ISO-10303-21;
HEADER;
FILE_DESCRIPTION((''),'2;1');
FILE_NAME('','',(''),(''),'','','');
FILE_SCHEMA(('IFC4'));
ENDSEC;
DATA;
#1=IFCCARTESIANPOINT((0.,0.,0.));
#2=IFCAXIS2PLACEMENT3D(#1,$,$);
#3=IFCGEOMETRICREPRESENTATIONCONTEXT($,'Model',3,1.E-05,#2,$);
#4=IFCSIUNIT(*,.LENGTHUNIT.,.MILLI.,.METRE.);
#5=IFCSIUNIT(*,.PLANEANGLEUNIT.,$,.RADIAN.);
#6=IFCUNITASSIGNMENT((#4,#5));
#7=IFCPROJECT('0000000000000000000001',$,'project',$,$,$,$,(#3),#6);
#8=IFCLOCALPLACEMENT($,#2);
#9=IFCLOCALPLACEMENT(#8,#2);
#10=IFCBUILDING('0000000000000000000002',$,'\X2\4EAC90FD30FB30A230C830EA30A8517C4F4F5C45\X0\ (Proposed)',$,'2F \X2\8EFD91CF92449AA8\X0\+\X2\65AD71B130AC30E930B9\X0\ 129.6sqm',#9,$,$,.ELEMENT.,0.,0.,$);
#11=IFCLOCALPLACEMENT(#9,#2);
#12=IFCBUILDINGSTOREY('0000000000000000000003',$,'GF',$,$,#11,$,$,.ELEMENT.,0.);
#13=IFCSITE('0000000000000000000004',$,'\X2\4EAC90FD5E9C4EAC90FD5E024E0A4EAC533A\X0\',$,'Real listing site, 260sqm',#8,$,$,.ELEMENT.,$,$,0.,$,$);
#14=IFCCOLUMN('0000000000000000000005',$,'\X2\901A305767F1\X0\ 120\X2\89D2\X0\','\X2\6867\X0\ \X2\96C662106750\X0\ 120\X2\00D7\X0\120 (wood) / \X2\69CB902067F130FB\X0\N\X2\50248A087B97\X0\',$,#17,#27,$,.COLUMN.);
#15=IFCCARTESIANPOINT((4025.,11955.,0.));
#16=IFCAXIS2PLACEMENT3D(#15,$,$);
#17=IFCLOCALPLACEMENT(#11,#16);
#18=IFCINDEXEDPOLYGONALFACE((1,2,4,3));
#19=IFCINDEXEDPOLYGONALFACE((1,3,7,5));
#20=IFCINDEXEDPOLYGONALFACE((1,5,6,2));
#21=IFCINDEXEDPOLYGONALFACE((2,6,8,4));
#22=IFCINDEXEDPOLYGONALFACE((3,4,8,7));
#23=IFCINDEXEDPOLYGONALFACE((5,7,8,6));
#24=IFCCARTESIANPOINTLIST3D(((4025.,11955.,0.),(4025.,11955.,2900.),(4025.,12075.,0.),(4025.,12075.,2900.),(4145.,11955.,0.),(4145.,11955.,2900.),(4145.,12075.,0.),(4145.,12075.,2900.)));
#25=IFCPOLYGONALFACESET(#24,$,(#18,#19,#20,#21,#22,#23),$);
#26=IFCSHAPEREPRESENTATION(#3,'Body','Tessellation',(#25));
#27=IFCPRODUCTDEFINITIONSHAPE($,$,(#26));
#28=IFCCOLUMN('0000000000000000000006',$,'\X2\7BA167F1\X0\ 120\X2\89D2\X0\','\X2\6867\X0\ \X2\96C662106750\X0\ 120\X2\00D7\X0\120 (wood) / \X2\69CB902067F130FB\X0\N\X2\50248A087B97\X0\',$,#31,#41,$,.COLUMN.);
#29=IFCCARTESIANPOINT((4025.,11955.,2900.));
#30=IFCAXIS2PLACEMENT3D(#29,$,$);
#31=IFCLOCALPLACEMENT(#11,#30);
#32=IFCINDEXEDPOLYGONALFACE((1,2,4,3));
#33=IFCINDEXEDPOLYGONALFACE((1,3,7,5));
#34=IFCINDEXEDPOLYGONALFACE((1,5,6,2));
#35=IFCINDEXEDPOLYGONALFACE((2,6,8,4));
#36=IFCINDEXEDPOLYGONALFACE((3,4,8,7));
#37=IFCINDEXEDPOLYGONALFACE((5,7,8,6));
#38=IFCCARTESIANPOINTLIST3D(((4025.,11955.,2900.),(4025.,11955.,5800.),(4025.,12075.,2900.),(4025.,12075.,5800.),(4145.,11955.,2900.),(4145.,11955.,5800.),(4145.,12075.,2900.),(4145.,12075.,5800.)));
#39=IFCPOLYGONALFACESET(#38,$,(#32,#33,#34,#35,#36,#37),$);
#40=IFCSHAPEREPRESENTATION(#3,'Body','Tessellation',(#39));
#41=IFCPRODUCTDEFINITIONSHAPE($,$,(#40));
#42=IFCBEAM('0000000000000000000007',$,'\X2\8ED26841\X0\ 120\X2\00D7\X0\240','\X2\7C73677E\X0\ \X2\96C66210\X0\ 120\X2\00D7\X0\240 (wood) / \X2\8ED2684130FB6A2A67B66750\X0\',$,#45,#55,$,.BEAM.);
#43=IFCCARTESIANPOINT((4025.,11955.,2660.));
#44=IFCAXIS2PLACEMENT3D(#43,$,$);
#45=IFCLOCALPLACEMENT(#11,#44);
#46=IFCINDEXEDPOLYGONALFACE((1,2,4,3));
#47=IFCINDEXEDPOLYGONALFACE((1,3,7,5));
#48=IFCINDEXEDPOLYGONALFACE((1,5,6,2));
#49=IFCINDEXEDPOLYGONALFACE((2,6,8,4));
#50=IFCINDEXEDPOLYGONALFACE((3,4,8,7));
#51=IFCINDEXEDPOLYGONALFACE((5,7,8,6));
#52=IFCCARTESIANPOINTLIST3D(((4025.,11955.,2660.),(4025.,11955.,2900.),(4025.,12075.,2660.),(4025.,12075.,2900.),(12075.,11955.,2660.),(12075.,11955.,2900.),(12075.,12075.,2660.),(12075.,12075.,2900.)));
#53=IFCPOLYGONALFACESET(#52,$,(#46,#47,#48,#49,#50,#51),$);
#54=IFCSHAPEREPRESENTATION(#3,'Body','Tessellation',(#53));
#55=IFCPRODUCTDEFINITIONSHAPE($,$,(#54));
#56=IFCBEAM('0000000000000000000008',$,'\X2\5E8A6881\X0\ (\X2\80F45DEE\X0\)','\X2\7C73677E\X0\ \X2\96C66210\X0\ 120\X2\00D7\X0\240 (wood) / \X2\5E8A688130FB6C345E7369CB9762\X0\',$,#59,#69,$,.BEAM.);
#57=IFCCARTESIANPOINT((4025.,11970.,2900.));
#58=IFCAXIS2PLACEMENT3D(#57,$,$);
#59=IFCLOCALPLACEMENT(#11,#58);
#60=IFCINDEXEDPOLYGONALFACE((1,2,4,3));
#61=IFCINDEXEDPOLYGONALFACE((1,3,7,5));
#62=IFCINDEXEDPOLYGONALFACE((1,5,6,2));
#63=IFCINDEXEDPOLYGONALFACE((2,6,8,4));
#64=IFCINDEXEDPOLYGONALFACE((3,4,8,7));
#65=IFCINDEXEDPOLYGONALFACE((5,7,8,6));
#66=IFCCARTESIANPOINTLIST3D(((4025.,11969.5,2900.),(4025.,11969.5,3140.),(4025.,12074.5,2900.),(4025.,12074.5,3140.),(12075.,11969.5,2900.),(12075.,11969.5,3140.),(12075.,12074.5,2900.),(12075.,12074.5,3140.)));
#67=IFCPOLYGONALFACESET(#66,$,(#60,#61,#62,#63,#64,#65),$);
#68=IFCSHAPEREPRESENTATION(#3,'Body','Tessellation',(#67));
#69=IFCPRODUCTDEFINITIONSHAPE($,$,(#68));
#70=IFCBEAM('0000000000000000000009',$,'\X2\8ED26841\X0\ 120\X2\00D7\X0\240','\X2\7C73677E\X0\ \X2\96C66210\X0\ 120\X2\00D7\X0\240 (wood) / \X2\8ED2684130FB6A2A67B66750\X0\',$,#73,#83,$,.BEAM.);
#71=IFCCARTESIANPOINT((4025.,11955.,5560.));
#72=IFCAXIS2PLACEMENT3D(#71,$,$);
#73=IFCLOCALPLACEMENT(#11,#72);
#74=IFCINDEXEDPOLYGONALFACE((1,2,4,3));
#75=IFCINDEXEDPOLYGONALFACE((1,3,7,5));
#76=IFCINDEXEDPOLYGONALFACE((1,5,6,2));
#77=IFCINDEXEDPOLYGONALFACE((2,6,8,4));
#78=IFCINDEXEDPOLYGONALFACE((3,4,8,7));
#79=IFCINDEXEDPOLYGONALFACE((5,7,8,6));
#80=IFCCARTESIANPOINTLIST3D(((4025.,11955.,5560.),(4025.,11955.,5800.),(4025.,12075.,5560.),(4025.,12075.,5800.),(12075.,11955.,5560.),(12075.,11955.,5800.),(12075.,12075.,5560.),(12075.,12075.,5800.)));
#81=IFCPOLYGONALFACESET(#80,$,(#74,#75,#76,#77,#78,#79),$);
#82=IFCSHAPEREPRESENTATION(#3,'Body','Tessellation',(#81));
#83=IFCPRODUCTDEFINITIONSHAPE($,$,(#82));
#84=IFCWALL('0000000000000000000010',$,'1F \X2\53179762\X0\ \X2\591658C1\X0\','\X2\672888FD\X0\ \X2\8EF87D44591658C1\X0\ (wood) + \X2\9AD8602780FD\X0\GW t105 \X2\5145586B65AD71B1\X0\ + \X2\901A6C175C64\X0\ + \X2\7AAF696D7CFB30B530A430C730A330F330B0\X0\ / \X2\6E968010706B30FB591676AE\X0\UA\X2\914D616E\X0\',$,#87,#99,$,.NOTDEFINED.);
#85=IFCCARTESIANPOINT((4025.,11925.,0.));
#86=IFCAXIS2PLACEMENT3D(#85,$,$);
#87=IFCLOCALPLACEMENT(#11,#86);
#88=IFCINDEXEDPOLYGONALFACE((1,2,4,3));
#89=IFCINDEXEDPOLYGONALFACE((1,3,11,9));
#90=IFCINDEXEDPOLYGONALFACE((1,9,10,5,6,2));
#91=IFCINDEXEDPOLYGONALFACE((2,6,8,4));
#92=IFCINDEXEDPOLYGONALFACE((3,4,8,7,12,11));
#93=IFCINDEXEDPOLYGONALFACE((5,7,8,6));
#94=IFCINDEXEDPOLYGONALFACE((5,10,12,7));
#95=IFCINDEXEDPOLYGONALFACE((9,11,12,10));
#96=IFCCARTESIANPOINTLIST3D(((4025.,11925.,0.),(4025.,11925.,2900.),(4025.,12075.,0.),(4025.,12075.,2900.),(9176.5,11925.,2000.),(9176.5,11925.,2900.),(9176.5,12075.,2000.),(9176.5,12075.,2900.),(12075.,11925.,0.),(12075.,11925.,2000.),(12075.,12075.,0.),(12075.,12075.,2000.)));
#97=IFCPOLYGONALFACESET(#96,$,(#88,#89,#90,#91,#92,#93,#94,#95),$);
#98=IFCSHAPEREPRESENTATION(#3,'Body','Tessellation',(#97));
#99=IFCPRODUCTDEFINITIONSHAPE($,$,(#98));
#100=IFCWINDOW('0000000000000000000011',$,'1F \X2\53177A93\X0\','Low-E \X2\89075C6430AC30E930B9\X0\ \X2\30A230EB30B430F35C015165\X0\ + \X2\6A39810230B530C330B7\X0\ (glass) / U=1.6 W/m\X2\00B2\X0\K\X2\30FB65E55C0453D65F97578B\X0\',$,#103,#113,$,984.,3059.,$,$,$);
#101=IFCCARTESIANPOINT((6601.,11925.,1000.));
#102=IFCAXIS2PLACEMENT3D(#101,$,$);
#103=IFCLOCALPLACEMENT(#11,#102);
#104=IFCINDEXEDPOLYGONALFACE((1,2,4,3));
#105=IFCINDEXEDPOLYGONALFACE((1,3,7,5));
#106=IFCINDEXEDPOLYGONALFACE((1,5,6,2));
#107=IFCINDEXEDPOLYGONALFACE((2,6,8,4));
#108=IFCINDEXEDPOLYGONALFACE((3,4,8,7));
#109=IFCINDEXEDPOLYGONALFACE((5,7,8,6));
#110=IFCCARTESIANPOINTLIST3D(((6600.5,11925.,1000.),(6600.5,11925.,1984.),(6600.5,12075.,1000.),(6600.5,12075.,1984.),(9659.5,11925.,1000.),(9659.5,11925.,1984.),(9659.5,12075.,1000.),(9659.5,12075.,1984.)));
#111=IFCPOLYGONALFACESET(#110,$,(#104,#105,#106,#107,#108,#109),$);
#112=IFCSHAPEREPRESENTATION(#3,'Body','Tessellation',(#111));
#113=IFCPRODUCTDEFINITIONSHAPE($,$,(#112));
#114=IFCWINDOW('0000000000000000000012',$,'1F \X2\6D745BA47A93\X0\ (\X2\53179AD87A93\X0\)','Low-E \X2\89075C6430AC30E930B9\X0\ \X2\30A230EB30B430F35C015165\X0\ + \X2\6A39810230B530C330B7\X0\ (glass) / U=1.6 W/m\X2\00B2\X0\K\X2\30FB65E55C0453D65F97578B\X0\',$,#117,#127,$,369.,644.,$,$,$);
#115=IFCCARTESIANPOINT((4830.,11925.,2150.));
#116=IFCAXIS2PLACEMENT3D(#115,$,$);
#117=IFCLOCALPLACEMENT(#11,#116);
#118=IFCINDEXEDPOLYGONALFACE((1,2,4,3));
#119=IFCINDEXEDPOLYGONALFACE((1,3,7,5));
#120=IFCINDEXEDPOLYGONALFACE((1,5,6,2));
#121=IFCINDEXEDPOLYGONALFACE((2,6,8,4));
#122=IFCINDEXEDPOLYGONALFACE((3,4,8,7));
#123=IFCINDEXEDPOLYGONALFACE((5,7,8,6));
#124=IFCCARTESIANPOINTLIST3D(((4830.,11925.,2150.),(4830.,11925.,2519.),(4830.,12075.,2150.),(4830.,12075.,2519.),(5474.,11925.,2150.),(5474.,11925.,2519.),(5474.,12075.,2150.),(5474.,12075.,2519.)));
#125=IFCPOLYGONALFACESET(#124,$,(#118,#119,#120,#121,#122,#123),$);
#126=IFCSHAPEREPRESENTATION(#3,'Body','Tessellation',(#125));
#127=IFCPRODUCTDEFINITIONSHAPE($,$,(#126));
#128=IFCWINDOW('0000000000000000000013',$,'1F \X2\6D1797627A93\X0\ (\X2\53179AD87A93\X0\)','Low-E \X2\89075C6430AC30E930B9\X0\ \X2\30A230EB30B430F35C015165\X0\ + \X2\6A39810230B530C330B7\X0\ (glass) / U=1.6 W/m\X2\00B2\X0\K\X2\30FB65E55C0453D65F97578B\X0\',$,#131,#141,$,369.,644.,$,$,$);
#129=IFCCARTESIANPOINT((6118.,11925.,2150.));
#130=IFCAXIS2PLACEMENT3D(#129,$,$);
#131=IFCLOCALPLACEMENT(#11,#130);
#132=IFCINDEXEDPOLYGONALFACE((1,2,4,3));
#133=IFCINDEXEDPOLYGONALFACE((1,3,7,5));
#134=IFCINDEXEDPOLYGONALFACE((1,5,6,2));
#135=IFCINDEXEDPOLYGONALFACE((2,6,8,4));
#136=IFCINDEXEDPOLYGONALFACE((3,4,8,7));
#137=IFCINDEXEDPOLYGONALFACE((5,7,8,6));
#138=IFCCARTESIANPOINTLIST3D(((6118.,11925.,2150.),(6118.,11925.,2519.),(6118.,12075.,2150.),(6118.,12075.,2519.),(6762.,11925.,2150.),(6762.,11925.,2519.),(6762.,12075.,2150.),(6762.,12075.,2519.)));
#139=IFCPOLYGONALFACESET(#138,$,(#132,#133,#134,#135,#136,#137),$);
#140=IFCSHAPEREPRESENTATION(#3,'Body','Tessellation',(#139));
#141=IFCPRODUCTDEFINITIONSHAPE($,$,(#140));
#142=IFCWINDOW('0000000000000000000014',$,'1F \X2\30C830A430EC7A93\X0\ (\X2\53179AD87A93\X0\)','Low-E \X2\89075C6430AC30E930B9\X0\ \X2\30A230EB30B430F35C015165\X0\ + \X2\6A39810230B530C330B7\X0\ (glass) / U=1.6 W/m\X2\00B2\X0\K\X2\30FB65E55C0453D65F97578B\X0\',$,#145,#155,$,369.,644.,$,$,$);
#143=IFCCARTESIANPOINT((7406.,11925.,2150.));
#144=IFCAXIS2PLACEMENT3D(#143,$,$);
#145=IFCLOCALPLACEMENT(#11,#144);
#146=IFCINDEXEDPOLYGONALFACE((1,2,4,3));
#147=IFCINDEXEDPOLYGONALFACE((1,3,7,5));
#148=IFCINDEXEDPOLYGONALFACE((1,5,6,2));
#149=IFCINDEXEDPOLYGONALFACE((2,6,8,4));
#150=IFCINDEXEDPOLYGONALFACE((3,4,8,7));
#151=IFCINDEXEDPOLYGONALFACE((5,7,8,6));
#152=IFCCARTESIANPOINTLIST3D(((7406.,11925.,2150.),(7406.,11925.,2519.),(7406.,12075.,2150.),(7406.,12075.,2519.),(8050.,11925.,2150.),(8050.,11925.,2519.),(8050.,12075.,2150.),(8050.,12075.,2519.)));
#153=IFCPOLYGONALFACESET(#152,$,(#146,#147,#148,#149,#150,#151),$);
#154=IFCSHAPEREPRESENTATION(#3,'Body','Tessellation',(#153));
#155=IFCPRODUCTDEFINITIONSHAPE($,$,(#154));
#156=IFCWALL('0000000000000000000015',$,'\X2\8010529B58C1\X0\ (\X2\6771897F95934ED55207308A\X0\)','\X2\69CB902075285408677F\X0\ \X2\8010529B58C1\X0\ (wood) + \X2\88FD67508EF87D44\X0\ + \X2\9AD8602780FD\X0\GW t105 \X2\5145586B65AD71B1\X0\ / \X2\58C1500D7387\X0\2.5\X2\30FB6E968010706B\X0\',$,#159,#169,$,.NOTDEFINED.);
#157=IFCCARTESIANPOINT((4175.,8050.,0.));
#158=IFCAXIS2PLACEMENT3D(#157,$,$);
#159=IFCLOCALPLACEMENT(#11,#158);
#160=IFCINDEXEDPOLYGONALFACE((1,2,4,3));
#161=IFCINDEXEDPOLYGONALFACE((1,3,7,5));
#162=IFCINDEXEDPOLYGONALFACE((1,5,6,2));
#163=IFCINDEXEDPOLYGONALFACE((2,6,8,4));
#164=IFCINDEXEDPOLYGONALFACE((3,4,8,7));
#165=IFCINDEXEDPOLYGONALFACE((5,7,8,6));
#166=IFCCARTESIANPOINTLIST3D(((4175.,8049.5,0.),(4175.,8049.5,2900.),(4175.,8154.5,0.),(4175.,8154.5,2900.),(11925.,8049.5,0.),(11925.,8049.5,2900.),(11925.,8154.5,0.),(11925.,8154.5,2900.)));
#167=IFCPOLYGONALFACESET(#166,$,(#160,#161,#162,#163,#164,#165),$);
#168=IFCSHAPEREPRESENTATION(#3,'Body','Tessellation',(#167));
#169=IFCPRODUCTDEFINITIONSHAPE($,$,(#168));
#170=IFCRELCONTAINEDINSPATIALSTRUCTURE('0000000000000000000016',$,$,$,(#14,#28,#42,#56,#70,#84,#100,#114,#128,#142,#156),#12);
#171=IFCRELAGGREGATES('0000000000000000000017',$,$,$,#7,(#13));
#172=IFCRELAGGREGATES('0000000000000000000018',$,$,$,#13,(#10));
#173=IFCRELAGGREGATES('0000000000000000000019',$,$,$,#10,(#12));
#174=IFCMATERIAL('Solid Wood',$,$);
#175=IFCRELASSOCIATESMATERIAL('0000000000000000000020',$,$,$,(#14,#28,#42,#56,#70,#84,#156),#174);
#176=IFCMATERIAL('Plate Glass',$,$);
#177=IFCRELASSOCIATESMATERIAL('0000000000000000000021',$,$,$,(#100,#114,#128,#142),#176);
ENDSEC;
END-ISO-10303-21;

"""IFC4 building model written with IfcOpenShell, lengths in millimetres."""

from ifc_helpers import new_model, si_unit, frame, frame_2d, origin, place, context, project, spatial, rectangle, extrude, material, element, fill, save


model = new_model("IFC4")

# Units and contexts
model_context = context("Model", 3, precision=1e-05, world=origin())
ifc_project = project(units=[si_unit("LENGTHUNIT", "METRE", prefix="MILLI"), si_unit("PLANEANGLEUNIT", "RADIAN")], contexts=[model_context])

# Site, building, storey
site_placement = place(None, origin())
site = spatial("IfcSite", under=ifc_project, at=site_placement, Name="京都府京都市上京区", ObjectType="Real listing site, 260sqm", CompositionType="ELEMENT", RefElevation=0.0)
building_placement = place(site_placement, origin())
building = spatial("IfcBuilding", under=site, at=building_placement, Name="京都・アトリエ兼住居 (Proposed)", ObjectType="2F 軽量鉄骨+断熱ガラス 129.6sqm", CompositionType="ELEMENT", ElevationOfRefHeight=0.0, ElevationOfTerrain=0.0)
storey_placement = place(building_placement, origin())
storey = spatial("IfcBuildingStorey", under=building, at=storey_placement, Name="GF", CompositionType="ELEMENT", Elevation=0.0)

# Columns
ifc_material_1 = material(Name="Solid Wood")
column_1_placement = place(storey_placement, frame((4025.0, 11955.0, 0.0)))
element("IfcColumn", 1, at=column_1_placement, inside=storey, material=ifc_material_1, Name="通し柱 120角", Description="桧 集成材 120×120 (wood) / 構造柱・N値計算", PredefinedType="COLUMN", context=model_context, shape_type="SweptSolid", body=[
    extrude(rectangle(XDim=120.0, YDim=120.0, at=frame_2d((60.0, 60.0))), frame((4025.0, 11955.0, 0.0)), (0.0, 0.0, 1.0), 2900.0),
])
column_2_placement = place(storey_placement, frame((4025.0, 11955.0, 2900.0)))
element("IfcColumn", 2, at=column_2_placement, inside=storey, material=ifc_material_1, Name="管柱 120角", Description="桧 集成材 120×120 (wood) / 構造柱・N値計算", PredefinedType="COLUMN", context=model_context, shape_type="SweptSolid", body=[
    extrude(rectangle(XDim=120.0, YDim=120.0, at=frame_2d((60.0, 60.0))), frame((4025.0, 11955.0, 2900.0)), (0.0, 0.0, 1.0), 2900.0),
])

# Beams
beam_1_placement = place(storey_placement, frame((4025.0, 11955.0, 2660.0)))
element("IfcBeam", 3, at=beam_1_placement, inside=storey, material=ifc_material_1, Name="軒桁 120×240", Description="米松 集成 120×240 (wood) / 軒桁・横架材", PredefinedType="BEAM", context=model_context, shape_type="SweptSolid", body=[
    extrude(rectangle(XDim=8050.0, YDim=120.0, at=frame_2d((4025.0, 60.0))), frame((4025.0, 11955.0, 2660.0)), (0.0, 0.0, 1.0), 240.0),
])
beam_2_placement = place(storey_placement, frame((4025.0, 11970.0, 2900.0)))
element("IfcBeam", 4, at=beam_2_placement, inside=storey, material=ifc_material_1, Name="床梁 (胴差)", Description="米松 集成 120×240 (wood) / 床梁・水平構面", PredefinedType="BEAM", context=model_context, shape_type="SweptSolid", body=[
    extrude(rectangle(XDim=8050.0, YDim=105.0, at=frame_2d((4025.0, 52.0))), frame((4025.0, 11970.0, 2900.0)), (0.0, 0.0, 1.0), 240.0),
])
beam_3_placement = place(storey_placement, frame((4025.0, 11955.0, 5560.0)))
element("IfcBeam", 5, at=beam_3_placement, inside=storey, material=ifc_material_1, Name="軒桁 120×240", Description="米松 集成 120×240 (wood) / 軒桁・横架材", PredefinedType="BEAM", context=model_context, shape_type="SweptSolid", body=[
    extrude(rectangle(XDim=8050.0, YDim=120.0, at=frame_2d((4025.0, 60.0))), frame((4025.0, 11955.0, 5560.0)), (0.0, 0.0, 1.0), 240.0),
])

# Wall, openings, windows
wall_1_placement = place(storey_placement, frame((4025.0, 11925.0, 0.0)))
wall_1 = element("IfcWall", 6, at=wall_1_placement, inside=storey, material=ifc_material_1, Name="1F 北面 外壁", Description="木製 軸組外壁 (wood) + 高性能GW t105 充填断熱 + 通気層 + 窯業系サイディング / 準耐火・外皮UA配慮", PredefinedType="NOTDEFINED", context=model_context, shape_type="SweptSolid", body=[
    extrude(rectangle(XDim=8050.0, YDim=150.0, at=frame_2d((4025.0, 75.0))), frame((4025.0, 11925.0, 0.0)), (0.0, 0.0, 1.0), 2900.0),
])
opening_1_placement = place(storey_placement, frame((6601.0, 11925.0, 1000.0)))
opening_1 = element("IfcOpeningElement", 7, at=opening_1_placement, cuts=wall_1, PredefinedType="NOTDEFINED", context=model_context, shape_type="SweptSolid", body=[
    extrude(rectangle(XDim=3059.0, YDim=150.0, at=frame_2d((1529.0, 75.0))), frame((6601.0, 11925.0, 1000.0)), (0.0, 0.0, 1.0), 984.0),
])
opening_2_placement = place(storey_placement, frame((4830.0, 11925.0, 2150.0)))
opening_2 = element("IfcOpeningElement", 8, at=opening_2_placement, cuts=wall_1, PredefinedType="NOTDEFINED", context=model_context, shape_type="SweptSolid", body=[
    extrude(rectangle(XDim=644.0, YDim=150.0, at=frame_2d((322.0, 75.0))), frame((4830.0, 11925.0, 2150.0)), (0.0, 0.0, 1.0), 369.0),
])
opening_3_placement = place(storey_placement, frame((6118.0, 11925.0, 2150.0)))
opening_3 = element("IfcOpeningElement", 9, at=opening_3_placement, cuts=wall_1, PredefinedType="NOTDEFINED", context=model_context, shape_type="SweptSolid", body=[
    extrude(rectangle(XDim=644.0, YDim=150.0, at=frame_2d((322.0, 75.0))), frame((6118.0, 11925.0, 2150.0)), (0.0, 0.0, 1.0), 369.0),
])
opening_4_placement = place(storey_placement, frame((7406.0, 11925.0, 2150.0)))
opening_4 = element("IfcOpeningElement", 10, at=opening_4_placement, cuts=wall_1, PredefinedType="NOTDEFINED", context=model_context, shape_type="SweptSolid", body=[
    extrude(rectangle(XDim=644.0, YDim=150.0, at=frame_2d((322.0, 75.0))), frame((7406.0, 11925.0, 2150.0)), (0.0, 0.0, 1.0), 369.0),
])
ifc_material_2 = material(Name="Plate Glass")
window_1_placement = place(storey_placement, frame((6601.0, 11925.0, 1000.0)))
window_1 = element("IfcWindow", 11, at=window_1_placement, inside=storey, material=ifc_material_2, Name="1F 北窓", Description="Low-E 複層ガラス アルゴン封入 + 樹脂サッシ (glass) / U=1.6 W/m²K・日射取得型", OverallHeight=984.0, OverallWidth=3059.0, context=model_context, shape_type="SweptSolid", body=[
    extrude(rectangle(XDim=3059.0, YDim=150.0, at=frame_2d((1529.0, 75.0))), frame((6601.0, 11925.0, 1000.0)), (0.0, 0.0, 1.0), 984.0),
])
fill(opening_1, window_1)
window_2_placement = place(storey_placement, frame((4830.0, 11925.0, 2150.0)))
window_2 = element("IfcWindow", 12, at=window_2_placement, inside=storey, material=ifc_material_2, Name="1F 浴室窓 (北高窓)", Description="Low-E 複層ガラス アルゴン封入 + 樹脂サッシ (glass) / U=1.6 W/m²K・日射取得型", OverallHeight=369.0, OverallWidth=644.0, context=model_context, shape_type="SweptSolid", body=[
    extrude(rectangle(XDim=644.0, YDim=150.0, at=frame_2d((322.0, 75.0))), frame((4830.0, 11925.0, 2150.0)), (0.0, 0.0, 1.0), 369.0),
])
fill(opening_2, window_2)
window_3_placement = place(storey_placement, frame((6118.0, 11925.0, 2150.0)))
window_3 = element("IfcWindow", 13, at=window_3_placement, inside=storey, material=ifc_material_2, Name="1F 洗面窓 (北高窓)", Description="Low-E 複層ガラス アルゴン封入 + 樹脂サッシ (glass) / U=1.6 W/m²K・日射取得型", OverallHeight=369.0, OverallWidth=644.0, context=model_context, shape_type="SweptSolid", body=[
    extrude(rectangle(XDim=644.0, YDim=150.0, at=frame_2d((322.0, 75.0))), frame((6118.0, 11925.0, 2150.0)), (0.0, 0.0, 1.0), 369.0),
])
fill(opening_3, window_3)
window_4_placement = place(storey_placement, frame((7406.0, 11925.0, 2150.0)))
window_4 = element("IfcWindow", 14, at=window_4_placement, inside=storey, material=ifc_material_2, Name="1F トイレ窓 (北高窓)", Description="Low-E 複層ガラス アルゴン封入 + 樹脂サッシ (glass) / U=1.6 W/m²K・日射取得型", OverallHeight=369.0, OverallWidth=644.0, context=model_context, shape_type="SweptSolid", body=[
    extrude(rectangle(XDim=644.0, YDim=150.0, at=frame_2d((322.0, 75.0))), frame((7406.0, 11925.0, 2150.0)), (0.0, 0.0, 1.0), 369.0),
])
fill(opening_4, window_4)

# Wall
wall_2_placement = place(storey_placement, frame((4175.0, 8050.0, 0.0)))
element("IfcWall", 15, at=wall_2_placement, inside=storey, material=ifc_material_1, Name="耐力壁 (東西間仕切り)", Description="構造用合板 耐力壁 (wood) + 製材軸組 + 高性能GW t105 充填断熱 / 壁倍率2.5・準耐火", PredefinedType="NOTDEFINED", context=model_context, shape_type="SweptSolid", body=[
    extrude(rectangle(XDim=7750.0, YDim=105.0, at=frame_2d((3875.0, 52.0))), frame((4175.0, 8050.0, 0.0)), (0.0, 0.0, 1.0), 2900.0),
])

save(model, "model.ifc")
